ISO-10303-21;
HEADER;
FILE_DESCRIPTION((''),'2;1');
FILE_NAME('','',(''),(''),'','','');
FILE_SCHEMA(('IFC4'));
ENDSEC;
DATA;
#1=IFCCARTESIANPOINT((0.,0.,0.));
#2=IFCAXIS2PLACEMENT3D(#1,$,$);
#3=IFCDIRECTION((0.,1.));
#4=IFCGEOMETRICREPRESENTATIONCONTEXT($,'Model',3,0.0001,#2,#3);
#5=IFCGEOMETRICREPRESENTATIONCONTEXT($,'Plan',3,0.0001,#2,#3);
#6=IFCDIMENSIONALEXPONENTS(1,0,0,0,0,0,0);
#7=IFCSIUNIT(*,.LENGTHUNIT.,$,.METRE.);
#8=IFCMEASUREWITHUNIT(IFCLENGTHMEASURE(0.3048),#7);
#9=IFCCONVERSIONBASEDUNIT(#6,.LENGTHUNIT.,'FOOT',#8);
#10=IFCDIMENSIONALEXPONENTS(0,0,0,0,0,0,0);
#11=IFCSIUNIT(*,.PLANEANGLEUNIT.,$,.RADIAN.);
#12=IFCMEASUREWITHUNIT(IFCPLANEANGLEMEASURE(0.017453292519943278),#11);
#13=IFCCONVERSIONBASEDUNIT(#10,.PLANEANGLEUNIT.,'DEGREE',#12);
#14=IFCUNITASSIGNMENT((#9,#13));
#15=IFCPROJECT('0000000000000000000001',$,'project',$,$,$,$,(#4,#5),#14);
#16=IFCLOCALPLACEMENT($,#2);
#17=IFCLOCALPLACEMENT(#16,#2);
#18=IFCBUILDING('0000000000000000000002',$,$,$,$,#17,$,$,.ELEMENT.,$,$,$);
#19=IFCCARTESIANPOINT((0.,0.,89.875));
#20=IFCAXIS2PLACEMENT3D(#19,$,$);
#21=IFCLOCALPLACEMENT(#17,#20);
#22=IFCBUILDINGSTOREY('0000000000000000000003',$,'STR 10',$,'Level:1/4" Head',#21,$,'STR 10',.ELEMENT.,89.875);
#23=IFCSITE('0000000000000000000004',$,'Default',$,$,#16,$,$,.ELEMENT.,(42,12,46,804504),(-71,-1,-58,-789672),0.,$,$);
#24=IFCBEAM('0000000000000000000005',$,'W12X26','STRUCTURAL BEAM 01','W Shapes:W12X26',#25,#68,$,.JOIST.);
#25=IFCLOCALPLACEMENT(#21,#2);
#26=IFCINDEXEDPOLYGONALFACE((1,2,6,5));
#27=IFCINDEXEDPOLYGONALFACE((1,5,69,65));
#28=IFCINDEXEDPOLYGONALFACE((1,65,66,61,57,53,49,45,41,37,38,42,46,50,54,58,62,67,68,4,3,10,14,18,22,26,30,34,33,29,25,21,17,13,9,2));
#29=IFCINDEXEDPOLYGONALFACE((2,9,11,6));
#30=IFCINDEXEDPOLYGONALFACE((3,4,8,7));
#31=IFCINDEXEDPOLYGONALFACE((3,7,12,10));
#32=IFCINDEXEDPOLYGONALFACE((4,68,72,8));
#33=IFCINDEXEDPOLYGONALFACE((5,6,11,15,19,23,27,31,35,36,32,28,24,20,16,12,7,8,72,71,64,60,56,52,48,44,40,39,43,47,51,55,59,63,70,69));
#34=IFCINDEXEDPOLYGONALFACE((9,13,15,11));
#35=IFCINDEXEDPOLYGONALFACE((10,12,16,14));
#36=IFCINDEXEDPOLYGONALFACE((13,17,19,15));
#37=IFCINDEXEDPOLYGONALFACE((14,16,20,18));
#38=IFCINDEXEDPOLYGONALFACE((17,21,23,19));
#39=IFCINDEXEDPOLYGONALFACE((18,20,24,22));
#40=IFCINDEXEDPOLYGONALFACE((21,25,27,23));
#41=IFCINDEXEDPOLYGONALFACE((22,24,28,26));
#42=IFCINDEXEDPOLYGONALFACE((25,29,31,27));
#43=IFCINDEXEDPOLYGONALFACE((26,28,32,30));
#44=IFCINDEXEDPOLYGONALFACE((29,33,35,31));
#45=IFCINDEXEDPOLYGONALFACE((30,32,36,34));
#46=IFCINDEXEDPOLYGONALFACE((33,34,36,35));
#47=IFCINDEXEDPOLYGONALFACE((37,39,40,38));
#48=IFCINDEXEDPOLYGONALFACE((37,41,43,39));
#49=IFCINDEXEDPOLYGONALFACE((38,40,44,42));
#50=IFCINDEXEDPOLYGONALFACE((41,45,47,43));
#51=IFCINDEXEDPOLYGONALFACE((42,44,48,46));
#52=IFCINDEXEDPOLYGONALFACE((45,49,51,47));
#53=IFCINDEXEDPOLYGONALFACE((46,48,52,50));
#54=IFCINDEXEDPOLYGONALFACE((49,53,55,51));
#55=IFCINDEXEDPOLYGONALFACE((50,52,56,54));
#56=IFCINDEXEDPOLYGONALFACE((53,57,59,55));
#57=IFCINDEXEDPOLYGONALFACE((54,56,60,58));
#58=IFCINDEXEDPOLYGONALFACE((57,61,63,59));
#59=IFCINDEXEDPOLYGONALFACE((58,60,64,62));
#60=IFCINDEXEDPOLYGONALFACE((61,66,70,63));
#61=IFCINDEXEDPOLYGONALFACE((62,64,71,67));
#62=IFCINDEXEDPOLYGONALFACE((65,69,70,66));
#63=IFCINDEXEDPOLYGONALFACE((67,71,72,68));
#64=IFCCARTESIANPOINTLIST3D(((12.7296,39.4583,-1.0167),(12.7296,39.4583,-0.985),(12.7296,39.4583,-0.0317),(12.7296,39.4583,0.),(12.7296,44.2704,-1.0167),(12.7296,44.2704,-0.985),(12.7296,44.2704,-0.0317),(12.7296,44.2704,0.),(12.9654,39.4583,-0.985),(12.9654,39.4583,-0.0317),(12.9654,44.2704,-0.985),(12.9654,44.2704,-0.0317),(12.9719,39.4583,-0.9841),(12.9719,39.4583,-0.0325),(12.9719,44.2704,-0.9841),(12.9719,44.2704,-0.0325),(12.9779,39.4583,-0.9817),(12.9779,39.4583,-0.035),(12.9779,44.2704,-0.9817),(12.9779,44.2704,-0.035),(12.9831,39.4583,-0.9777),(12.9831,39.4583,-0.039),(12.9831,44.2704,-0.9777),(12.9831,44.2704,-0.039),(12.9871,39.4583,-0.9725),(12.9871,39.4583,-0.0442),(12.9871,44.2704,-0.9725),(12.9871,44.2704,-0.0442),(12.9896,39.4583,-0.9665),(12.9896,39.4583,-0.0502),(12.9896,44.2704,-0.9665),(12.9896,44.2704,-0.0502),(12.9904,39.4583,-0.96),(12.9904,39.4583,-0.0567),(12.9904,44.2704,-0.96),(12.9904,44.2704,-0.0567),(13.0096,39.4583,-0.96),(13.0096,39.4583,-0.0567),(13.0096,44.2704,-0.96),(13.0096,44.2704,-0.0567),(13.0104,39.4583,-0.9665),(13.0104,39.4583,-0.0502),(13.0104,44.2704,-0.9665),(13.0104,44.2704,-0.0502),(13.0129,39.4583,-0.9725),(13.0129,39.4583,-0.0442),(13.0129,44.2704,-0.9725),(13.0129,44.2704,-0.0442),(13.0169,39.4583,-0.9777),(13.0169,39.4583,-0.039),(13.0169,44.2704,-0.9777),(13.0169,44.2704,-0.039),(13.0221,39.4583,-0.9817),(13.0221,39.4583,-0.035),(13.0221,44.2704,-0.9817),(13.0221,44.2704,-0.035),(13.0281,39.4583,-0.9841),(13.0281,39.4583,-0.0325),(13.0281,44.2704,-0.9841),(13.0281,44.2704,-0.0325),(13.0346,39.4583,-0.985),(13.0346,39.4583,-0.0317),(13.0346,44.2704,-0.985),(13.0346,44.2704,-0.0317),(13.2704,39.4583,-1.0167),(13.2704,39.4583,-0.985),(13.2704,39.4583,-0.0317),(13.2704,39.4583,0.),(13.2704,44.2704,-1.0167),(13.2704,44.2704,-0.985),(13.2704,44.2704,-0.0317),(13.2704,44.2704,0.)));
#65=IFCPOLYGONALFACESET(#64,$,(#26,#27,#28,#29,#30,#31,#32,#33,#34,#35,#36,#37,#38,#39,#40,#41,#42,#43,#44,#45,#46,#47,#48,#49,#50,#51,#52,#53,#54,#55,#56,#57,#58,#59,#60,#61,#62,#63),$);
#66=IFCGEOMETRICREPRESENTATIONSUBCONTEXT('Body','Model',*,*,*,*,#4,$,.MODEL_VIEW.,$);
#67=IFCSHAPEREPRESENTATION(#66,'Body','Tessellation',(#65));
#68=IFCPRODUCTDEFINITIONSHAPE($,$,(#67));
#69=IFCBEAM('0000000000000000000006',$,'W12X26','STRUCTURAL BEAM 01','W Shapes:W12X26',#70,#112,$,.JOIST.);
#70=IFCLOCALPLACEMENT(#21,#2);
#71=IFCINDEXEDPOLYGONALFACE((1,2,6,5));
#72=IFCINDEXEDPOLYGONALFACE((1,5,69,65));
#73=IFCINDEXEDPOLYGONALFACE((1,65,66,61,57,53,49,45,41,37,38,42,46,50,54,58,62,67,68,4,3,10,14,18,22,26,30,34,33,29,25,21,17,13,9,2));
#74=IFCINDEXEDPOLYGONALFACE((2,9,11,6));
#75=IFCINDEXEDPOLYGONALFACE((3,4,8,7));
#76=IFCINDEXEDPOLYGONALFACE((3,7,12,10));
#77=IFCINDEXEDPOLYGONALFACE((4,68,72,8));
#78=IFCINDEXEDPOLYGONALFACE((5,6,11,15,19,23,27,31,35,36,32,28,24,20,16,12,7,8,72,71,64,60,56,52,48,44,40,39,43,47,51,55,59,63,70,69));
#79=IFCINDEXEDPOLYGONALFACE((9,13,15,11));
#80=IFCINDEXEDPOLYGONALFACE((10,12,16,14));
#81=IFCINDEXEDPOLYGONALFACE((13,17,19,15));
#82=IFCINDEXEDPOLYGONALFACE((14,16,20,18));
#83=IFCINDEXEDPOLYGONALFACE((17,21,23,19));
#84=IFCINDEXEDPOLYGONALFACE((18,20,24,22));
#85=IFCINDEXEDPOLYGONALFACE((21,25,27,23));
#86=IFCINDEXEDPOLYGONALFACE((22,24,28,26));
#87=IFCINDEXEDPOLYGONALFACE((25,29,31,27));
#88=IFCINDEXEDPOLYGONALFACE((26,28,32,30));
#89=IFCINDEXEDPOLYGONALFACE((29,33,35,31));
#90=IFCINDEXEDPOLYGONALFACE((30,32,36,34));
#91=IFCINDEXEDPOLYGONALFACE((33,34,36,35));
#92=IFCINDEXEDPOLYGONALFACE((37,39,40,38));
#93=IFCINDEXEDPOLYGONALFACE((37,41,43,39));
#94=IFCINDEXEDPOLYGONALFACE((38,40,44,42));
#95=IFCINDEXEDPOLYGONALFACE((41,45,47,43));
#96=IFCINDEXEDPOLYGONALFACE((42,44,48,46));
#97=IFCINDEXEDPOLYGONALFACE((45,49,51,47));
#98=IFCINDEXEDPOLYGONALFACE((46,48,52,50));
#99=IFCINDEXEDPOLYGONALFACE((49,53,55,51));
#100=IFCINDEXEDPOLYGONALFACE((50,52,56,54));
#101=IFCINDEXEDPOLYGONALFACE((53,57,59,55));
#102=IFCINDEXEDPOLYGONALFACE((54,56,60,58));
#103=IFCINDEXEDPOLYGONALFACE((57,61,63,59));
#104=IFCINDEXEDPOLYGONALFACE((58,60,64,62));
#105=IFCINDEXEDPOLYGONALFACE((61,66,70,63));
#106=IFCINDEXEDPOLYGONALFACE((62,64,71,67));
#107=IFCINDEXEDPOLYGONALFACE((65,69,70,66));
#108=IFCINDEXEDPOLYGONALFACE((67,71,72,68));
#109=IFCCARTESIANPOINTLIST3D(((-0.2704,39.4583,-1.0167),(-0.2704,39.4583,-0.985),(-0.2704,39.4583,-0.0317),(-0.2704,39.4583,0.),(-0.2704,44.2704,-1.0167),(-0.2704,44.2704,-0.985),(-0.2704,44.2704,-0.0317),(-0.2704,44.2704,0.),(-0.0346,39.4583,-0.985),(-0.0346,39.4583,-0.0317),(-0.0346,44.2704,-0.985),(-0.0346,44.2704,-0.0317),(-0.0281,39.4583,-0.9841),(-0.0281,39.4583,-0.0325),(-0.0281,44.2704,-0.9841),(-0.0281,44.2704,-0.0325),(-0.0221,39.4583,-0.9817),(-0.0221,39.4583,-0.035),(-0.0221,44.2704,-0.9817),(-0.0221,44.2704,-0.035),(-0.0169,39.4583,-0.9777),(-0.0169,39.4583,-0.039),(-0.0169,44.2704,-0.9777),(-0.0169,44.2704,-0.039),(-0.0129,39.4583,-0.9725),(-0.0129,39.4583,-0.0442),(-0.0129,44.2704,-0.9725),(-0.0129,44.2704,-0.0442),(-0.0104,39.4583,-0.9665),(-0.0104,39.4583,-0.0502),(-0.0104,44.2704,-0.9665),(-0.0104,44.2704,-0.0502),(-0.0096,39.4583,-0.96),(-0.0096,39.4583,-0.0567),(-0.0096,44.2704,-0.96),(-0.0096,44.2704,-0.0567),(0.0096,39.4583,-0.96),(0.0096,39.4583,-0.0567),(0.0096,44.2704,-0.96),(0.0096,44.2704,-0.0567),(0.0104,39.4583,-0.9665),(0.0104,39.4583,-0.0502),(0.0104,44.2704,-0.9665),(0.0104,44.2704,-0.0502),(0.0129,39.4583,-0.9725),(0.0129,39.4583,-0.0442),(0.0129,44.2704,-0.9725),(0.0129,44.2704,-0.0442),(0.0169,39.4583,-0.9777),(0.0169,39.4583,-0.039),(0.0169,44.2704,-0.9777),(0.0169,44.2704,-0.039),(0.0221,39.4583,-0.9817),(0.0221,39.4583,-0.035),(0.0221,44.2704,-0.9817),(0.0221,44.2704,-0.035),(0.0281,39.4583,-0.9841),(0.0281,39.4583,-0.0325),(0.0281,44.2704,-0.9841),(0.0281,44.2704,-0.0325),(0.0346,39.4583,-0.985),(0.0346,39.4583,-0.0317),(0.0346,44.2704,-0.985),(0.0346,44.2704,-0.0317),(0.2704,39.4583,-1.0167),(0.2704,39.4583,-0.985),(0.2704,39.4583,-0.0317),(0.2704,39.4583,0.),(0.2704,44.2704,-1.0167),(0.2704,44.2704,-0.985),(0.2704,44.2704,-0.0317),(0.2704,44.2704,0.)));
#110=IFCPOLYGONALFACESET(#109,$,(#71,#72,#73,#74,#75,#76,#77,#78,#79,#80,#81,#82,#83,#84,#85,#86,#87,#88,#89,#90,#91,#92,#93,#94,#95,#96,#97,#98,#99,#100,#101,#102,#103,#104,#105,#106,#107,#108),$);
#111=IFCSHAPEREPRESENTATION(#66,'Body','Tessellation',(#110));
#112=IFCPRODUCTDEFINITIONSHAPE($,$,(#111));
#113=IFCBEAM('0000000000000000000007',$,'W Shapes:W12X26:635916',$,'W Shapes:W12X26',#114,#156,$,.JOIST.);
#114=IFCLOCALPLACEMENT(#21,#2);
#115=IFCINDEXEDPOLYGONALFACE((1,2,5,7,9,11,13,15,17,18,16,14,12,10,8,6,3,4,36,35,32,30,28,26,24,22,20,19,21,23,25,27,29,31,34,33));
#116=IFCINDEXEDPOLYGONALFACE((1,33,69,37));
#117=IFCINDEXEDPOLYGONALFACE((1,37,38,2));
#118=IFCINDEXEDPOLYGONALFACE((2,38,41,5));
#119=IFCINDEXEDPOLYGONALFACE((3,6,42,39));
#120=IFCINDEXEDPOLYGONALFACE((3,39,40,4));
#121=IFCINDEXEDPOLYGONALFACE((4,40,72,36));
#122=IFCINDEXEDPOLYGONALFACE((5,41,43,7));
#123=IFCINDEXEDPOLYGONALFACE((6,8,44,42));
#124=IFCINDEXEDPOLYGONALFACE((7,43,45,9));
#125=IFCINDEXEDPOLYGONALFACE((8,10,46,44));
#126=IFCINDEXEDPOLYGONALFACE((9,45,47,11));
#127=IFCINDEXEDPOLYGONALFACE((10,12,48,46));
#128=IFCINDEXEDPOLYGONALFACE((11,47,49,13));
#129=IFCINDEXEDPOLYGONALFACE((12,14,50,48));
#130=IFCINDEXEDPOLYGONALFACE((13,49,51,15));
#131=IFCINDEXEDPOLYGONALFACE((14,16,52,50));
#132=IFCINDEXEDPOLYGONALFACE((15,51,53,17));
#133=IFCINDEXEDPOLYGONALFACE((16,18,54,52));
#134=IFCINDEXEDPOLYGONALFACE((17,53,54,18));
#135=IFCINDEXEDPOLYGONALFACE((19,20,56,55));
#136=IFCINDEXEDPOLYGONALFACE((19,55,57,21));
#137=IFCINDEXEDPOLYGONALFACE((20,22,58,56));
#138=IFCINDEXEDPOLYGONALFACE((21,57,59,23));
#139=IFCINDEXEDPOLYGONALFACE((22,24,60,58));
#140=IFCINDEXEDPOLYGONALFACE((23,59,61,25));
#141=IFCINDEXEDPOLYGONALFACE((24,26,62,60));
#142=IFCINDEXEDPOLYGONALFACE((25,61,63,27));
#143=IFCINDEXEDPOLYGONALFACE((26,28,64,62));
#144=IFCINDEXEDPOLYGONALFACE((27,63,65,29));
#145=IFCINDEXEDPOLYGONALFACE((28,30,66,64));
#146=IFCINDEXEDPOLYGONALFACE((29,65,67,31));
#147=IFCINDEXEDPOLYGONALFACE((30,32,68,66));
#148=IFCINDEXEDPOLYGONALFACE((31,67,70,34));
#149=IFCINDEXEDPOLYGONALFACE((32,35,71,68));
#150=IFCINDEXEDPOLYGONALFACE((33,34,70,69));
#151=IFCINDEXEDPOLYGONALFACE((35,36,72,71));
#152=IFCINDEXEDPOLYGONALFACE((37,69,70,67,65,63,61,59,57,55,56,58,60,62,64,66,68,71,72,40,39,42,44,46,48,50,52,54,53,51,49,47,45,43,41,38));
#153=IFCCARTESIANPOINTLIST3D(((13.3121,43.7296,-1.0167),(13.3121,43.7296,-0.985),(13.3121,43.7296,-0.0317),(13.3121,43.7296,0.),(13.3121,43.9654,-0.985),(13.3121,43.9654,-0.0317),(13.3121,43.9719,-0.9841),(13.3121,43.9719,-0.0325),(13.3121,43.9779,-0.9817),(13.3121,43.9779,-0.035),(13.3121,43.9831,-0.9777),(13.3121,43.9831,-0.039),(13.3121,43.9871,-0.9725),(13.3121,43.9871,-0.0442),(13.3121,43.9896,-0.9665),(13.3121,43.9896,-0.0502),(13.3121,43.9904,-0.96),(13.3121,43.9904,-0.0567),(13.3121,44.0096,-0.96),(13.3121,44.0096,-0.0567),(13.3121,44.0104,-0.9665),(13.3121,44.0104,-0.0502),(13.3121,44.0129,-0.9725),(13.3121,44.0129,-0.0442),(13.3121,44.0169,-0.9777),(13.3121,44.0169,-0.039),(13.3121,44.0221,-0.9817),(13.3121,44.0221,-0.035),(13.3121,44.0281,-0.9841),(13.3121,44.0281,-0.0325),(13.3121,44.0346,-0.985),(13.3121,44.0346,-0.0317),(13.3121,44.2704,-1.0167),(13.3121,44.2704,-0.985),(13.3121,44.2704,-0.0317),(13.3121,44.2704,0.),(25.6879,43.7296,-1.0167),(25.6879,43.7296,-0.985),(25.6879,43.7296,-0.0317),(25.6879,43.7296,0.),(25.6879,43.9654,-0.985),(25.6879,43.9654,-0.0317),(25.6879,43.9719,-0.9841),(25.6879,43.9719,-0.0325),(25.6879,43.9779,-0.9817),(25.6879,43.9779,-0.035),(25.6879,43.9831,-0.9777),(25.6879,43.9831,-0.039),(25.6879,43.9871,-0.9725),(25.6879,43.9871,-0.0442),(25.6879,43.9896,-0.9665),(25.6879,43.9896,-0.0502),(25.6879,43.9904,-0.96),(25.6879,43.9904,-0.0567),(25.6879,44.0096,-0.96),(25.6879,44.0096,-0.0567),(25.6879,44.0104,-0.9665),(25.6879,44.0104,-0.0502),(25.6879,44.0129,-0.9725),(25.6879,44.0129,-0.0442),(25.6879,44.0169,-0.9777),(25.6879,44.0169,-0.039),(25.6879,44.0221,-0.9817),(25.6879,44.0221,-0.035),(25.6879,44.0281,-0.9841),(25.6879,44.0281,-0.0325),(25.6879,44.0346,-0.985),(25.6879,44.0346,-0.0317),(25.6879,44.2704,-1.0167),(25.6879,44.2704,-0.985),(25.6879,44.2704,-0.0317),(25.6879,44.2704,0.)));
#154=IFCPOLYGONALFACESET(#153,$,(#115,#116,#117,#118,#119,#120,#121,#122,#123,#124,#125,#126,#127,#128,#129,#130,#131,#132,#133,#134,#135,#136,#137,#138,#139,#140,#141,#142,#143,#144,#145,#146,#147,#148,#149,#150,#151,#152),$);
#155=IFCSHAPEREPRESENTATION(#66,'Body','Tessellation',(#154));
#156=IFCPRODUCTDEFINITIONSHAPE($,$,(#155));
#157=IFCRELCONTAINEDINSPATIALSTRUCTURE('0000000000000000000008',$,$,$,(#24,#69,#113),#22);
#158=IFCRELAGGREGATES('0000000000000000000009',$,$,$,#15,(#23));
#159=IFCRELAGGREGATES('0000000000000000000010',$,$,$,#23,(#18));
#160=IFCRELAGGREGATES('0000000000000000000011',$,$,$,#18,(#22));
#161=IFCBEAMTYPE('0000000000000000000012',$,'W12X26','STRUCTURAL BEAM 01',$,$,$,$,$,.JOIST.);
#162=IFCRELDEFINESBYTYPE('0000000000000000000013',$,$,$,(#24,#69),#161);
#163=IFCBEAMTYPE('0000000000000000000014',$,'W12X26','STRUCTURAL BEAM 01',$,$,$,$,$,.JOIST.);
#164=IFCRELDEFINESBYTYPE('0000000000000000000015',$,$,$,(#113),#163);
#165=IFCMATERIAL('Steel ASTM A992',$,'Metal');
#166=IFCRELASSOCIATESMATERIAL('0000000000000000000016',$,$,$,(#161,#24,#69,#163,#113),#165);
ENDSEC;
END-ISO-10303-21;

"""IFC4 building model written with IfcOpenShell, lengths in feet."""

from ifc_helpers import new_model, entity, si_unit, converted_unit, direction, frame, origin, place, context, subcontext, project, spatial, line, arc, indexed_curve, outline, extrude, source, transform, mapped, material, type_object, type_shapes, element, save


model = new_model("IFC4")

# Units and contexts
model_context = context("Model", 3, precision=0.0001, world=origin(), true_north=direction((0.0, 1.0)))
plan_context = context("Plan", 3, precision=0.0001, world=origin(), true_north=direction((0.0, 1.0)))
body_context = subcontext(model_context, "Body", "Model", "MODEL_VIEW")
ifc_project = project(units=[converted_unit("LENGTHUNIT", "FOOT", entity("IfcLengthMeasure", 0.3048), si_unit("LENGTHUNIT", "METRE"), dimensions=[1, 0, 0, 0, 0, 0, 0]), converted_unit("PLANEANGLEUNIT", "DEGREE", entity("IfcPlaneAngleMeasure", 0.017453292519943278), si_unit("PLANEANGLEUNIT", "RADIAN"), dimensions=[0, 0, 0, 0, 0, 0, 0])], contexts=[model_context, plan_context])

# Site, building, storey
site_placement = place(None, origin())
site = spatial("IfcSite", under=ifc_project, at=site_placement, Name="Default", CompositionType="ELEMENT", RefLatitude=(42, 12, 46, 804504), RefLongitude=(-71, -1, -58, -789672), RefElevation=0.0)
building_placement = place(site_placement, origin())
building = spatial("IfcBuilding", under=site, at=building_placement, CompositionType="ELEMENT")
storey_placement = place(building_placement, frame((0.0, 0.0, 89.875)))
storey = spatial("IfcBuildingStorey", under=building, at=storey_placement, Name="STR 10", ObjectType="Level:1/4\" Head", LongName="STR 10", CompositionType="ELEMENT", Elevation=89.875)

# Beams
ifc_material = material(Name="Steel ASTM A992", Category="Metal")
beam_type_1 = type_object("IfcBeamType", Name="W12X26", Description="STRUCTURAL BEAM 01", PredefinedType="JOIST", material=ifc_material)
shared_shape_1 = source(origin(), body_context, "Body", "SweptSolid", [
    extrude(outline(indexed_curve([(0.4767, -0.2704), (0.5083, -0.2704), (0.5083, 0.2704), (0.4767, 0.2704), (0.4767, 0.0346), (0.4693, 0.0169), (0.4517, 0.0096), (-0.4517, 0.0096), (-0.4693, 0.0169), (-0.4767, 0.0346), (-0.4767, 0.2704), (-0.5083, 0.2704), (-0.5083, -0.2704), (-0.4767, -0.2704), (-0.4767, -0.0346), (-0.4693, -0.0169), (-0.4517, -0.0096), (0.4517, -0.0096), (0.4693, -0.0169), (0.4767, -0.0346)], segments=[line(1, 2, 3, 4, 5), arc(5, 6, 7), line(7, 8), arc(8, 9, 10), line(10, 11, 12, 13, 14, 15), arc(15, 16, 17), line(17, 18), arc(18, 19, 20), line(20, 1)], self_intersect=False)), frame((-2.7704, 0.0, 0.0), z_axis=(1.0, 0.0, 0.0), x_axis=(0.0, 0.0, -1.0)), (0.0, 0.0, 1.0), 4.8121),
])
type_shapes(beam_type_1, [shared_shape_1])
for number, where, z_axis, x_axis, name in (
    (1, (13.0, 41.5, -0.5083), (0.0, 0.0, 1.0), (0.0, -1.0, 0.0), "W12X26"),
    (2, (0.0, 41.5, -0.5083), (0.0, 0.0, 1.0), (0.0, -1.0, 0.0), "W12X26"),
):
    element("IfcBeam", number, at=place(storey_placement, frame(where, z_axis=z_axis, x_axis=x_axis)), inside=storey, type_object=beam_type_1, material=ifc_material, Name=name, Description="STRUCTURAL BEAM 01", ObjectType="W Shapes:W12X26", PredefinedType="JOIST", context=body_context, shape_type="MappedRepresentation", body=[
        mapped(shared_shape_1, transform((0.0, 0.0, 0.0), scale=1.0)),
    ])
beam_type_2 = type_object("IfcBeamType", Name="W12X26", Description="STRUCTURAL BEAM 01", PredefinedType="JOIST", material=ifc_material)
shared_shape_2 = source(origin(), body_context, "Body", "SweptSolid", [
    extrude(outline(indexed_curve([(0.4767, -0.2704), (0.5083, -0.2704), (0.5083, 0.2704), (0.4767, 0.2704), (0.4767, 0.0346), (0.4693, 0.0169), (0.4517, 0.0096), (-0.4517, 0.0096), (-0.4693, 0.0169), (-0.4767, 0.0346), (-0.4767, 0.2704), (-0.5083, 0.2704), (-0.5083, -0.2704), (-0.4767, -0.2704), (-0.4767, -0.0346), (-0.4693, -0.0169), (-0.4517, -0.0096), (0.4517, -0.0096), (0.4693, -0.0169), (0.4767, -0.0346)], segments=[line(1, 2, 3, 4, 5), arc(5, 6, 7), line(7, 8), arc(8, 9, 10), line(10, 11, 12, 13, 14, 15), arc(15, 16, 17), line(17, 18), arc(18, 19, 20), line(20, 1)], self_intersect=False)), frame((-6.1879, 0.0, 0.0), z_axis=(1.0, 0.0, 0.0), x_axis=(0.0, 0.0, -1.0)), (0.0, 0.0, 1.0), 12.3758),
])
type_shapes(beam_type_2, [shared_shape_2])
beam_1_placement = place(storey_placement, frame((19.5, 44.0, -0.5083), z_axis=(0.0, 0.0, 1.0), x_axis=(-1.0, 0.0, 0.0)))
element("IfcBeam", 3, at=beam_1_placement, inside=storey, type_object=beam_type_2, material=ifc_material, Name="W Shapes:W12X26:635916", ObjectType="W Shapes:W12X26", PredefinedType="JOIST", context=body_context, shape_type="MappedRepresentation", body=[
    mapped(shared_shape_2, transform((0.0, 0.0, 0.0), scale=1.0)),
])

save(model, "model.ifc")
